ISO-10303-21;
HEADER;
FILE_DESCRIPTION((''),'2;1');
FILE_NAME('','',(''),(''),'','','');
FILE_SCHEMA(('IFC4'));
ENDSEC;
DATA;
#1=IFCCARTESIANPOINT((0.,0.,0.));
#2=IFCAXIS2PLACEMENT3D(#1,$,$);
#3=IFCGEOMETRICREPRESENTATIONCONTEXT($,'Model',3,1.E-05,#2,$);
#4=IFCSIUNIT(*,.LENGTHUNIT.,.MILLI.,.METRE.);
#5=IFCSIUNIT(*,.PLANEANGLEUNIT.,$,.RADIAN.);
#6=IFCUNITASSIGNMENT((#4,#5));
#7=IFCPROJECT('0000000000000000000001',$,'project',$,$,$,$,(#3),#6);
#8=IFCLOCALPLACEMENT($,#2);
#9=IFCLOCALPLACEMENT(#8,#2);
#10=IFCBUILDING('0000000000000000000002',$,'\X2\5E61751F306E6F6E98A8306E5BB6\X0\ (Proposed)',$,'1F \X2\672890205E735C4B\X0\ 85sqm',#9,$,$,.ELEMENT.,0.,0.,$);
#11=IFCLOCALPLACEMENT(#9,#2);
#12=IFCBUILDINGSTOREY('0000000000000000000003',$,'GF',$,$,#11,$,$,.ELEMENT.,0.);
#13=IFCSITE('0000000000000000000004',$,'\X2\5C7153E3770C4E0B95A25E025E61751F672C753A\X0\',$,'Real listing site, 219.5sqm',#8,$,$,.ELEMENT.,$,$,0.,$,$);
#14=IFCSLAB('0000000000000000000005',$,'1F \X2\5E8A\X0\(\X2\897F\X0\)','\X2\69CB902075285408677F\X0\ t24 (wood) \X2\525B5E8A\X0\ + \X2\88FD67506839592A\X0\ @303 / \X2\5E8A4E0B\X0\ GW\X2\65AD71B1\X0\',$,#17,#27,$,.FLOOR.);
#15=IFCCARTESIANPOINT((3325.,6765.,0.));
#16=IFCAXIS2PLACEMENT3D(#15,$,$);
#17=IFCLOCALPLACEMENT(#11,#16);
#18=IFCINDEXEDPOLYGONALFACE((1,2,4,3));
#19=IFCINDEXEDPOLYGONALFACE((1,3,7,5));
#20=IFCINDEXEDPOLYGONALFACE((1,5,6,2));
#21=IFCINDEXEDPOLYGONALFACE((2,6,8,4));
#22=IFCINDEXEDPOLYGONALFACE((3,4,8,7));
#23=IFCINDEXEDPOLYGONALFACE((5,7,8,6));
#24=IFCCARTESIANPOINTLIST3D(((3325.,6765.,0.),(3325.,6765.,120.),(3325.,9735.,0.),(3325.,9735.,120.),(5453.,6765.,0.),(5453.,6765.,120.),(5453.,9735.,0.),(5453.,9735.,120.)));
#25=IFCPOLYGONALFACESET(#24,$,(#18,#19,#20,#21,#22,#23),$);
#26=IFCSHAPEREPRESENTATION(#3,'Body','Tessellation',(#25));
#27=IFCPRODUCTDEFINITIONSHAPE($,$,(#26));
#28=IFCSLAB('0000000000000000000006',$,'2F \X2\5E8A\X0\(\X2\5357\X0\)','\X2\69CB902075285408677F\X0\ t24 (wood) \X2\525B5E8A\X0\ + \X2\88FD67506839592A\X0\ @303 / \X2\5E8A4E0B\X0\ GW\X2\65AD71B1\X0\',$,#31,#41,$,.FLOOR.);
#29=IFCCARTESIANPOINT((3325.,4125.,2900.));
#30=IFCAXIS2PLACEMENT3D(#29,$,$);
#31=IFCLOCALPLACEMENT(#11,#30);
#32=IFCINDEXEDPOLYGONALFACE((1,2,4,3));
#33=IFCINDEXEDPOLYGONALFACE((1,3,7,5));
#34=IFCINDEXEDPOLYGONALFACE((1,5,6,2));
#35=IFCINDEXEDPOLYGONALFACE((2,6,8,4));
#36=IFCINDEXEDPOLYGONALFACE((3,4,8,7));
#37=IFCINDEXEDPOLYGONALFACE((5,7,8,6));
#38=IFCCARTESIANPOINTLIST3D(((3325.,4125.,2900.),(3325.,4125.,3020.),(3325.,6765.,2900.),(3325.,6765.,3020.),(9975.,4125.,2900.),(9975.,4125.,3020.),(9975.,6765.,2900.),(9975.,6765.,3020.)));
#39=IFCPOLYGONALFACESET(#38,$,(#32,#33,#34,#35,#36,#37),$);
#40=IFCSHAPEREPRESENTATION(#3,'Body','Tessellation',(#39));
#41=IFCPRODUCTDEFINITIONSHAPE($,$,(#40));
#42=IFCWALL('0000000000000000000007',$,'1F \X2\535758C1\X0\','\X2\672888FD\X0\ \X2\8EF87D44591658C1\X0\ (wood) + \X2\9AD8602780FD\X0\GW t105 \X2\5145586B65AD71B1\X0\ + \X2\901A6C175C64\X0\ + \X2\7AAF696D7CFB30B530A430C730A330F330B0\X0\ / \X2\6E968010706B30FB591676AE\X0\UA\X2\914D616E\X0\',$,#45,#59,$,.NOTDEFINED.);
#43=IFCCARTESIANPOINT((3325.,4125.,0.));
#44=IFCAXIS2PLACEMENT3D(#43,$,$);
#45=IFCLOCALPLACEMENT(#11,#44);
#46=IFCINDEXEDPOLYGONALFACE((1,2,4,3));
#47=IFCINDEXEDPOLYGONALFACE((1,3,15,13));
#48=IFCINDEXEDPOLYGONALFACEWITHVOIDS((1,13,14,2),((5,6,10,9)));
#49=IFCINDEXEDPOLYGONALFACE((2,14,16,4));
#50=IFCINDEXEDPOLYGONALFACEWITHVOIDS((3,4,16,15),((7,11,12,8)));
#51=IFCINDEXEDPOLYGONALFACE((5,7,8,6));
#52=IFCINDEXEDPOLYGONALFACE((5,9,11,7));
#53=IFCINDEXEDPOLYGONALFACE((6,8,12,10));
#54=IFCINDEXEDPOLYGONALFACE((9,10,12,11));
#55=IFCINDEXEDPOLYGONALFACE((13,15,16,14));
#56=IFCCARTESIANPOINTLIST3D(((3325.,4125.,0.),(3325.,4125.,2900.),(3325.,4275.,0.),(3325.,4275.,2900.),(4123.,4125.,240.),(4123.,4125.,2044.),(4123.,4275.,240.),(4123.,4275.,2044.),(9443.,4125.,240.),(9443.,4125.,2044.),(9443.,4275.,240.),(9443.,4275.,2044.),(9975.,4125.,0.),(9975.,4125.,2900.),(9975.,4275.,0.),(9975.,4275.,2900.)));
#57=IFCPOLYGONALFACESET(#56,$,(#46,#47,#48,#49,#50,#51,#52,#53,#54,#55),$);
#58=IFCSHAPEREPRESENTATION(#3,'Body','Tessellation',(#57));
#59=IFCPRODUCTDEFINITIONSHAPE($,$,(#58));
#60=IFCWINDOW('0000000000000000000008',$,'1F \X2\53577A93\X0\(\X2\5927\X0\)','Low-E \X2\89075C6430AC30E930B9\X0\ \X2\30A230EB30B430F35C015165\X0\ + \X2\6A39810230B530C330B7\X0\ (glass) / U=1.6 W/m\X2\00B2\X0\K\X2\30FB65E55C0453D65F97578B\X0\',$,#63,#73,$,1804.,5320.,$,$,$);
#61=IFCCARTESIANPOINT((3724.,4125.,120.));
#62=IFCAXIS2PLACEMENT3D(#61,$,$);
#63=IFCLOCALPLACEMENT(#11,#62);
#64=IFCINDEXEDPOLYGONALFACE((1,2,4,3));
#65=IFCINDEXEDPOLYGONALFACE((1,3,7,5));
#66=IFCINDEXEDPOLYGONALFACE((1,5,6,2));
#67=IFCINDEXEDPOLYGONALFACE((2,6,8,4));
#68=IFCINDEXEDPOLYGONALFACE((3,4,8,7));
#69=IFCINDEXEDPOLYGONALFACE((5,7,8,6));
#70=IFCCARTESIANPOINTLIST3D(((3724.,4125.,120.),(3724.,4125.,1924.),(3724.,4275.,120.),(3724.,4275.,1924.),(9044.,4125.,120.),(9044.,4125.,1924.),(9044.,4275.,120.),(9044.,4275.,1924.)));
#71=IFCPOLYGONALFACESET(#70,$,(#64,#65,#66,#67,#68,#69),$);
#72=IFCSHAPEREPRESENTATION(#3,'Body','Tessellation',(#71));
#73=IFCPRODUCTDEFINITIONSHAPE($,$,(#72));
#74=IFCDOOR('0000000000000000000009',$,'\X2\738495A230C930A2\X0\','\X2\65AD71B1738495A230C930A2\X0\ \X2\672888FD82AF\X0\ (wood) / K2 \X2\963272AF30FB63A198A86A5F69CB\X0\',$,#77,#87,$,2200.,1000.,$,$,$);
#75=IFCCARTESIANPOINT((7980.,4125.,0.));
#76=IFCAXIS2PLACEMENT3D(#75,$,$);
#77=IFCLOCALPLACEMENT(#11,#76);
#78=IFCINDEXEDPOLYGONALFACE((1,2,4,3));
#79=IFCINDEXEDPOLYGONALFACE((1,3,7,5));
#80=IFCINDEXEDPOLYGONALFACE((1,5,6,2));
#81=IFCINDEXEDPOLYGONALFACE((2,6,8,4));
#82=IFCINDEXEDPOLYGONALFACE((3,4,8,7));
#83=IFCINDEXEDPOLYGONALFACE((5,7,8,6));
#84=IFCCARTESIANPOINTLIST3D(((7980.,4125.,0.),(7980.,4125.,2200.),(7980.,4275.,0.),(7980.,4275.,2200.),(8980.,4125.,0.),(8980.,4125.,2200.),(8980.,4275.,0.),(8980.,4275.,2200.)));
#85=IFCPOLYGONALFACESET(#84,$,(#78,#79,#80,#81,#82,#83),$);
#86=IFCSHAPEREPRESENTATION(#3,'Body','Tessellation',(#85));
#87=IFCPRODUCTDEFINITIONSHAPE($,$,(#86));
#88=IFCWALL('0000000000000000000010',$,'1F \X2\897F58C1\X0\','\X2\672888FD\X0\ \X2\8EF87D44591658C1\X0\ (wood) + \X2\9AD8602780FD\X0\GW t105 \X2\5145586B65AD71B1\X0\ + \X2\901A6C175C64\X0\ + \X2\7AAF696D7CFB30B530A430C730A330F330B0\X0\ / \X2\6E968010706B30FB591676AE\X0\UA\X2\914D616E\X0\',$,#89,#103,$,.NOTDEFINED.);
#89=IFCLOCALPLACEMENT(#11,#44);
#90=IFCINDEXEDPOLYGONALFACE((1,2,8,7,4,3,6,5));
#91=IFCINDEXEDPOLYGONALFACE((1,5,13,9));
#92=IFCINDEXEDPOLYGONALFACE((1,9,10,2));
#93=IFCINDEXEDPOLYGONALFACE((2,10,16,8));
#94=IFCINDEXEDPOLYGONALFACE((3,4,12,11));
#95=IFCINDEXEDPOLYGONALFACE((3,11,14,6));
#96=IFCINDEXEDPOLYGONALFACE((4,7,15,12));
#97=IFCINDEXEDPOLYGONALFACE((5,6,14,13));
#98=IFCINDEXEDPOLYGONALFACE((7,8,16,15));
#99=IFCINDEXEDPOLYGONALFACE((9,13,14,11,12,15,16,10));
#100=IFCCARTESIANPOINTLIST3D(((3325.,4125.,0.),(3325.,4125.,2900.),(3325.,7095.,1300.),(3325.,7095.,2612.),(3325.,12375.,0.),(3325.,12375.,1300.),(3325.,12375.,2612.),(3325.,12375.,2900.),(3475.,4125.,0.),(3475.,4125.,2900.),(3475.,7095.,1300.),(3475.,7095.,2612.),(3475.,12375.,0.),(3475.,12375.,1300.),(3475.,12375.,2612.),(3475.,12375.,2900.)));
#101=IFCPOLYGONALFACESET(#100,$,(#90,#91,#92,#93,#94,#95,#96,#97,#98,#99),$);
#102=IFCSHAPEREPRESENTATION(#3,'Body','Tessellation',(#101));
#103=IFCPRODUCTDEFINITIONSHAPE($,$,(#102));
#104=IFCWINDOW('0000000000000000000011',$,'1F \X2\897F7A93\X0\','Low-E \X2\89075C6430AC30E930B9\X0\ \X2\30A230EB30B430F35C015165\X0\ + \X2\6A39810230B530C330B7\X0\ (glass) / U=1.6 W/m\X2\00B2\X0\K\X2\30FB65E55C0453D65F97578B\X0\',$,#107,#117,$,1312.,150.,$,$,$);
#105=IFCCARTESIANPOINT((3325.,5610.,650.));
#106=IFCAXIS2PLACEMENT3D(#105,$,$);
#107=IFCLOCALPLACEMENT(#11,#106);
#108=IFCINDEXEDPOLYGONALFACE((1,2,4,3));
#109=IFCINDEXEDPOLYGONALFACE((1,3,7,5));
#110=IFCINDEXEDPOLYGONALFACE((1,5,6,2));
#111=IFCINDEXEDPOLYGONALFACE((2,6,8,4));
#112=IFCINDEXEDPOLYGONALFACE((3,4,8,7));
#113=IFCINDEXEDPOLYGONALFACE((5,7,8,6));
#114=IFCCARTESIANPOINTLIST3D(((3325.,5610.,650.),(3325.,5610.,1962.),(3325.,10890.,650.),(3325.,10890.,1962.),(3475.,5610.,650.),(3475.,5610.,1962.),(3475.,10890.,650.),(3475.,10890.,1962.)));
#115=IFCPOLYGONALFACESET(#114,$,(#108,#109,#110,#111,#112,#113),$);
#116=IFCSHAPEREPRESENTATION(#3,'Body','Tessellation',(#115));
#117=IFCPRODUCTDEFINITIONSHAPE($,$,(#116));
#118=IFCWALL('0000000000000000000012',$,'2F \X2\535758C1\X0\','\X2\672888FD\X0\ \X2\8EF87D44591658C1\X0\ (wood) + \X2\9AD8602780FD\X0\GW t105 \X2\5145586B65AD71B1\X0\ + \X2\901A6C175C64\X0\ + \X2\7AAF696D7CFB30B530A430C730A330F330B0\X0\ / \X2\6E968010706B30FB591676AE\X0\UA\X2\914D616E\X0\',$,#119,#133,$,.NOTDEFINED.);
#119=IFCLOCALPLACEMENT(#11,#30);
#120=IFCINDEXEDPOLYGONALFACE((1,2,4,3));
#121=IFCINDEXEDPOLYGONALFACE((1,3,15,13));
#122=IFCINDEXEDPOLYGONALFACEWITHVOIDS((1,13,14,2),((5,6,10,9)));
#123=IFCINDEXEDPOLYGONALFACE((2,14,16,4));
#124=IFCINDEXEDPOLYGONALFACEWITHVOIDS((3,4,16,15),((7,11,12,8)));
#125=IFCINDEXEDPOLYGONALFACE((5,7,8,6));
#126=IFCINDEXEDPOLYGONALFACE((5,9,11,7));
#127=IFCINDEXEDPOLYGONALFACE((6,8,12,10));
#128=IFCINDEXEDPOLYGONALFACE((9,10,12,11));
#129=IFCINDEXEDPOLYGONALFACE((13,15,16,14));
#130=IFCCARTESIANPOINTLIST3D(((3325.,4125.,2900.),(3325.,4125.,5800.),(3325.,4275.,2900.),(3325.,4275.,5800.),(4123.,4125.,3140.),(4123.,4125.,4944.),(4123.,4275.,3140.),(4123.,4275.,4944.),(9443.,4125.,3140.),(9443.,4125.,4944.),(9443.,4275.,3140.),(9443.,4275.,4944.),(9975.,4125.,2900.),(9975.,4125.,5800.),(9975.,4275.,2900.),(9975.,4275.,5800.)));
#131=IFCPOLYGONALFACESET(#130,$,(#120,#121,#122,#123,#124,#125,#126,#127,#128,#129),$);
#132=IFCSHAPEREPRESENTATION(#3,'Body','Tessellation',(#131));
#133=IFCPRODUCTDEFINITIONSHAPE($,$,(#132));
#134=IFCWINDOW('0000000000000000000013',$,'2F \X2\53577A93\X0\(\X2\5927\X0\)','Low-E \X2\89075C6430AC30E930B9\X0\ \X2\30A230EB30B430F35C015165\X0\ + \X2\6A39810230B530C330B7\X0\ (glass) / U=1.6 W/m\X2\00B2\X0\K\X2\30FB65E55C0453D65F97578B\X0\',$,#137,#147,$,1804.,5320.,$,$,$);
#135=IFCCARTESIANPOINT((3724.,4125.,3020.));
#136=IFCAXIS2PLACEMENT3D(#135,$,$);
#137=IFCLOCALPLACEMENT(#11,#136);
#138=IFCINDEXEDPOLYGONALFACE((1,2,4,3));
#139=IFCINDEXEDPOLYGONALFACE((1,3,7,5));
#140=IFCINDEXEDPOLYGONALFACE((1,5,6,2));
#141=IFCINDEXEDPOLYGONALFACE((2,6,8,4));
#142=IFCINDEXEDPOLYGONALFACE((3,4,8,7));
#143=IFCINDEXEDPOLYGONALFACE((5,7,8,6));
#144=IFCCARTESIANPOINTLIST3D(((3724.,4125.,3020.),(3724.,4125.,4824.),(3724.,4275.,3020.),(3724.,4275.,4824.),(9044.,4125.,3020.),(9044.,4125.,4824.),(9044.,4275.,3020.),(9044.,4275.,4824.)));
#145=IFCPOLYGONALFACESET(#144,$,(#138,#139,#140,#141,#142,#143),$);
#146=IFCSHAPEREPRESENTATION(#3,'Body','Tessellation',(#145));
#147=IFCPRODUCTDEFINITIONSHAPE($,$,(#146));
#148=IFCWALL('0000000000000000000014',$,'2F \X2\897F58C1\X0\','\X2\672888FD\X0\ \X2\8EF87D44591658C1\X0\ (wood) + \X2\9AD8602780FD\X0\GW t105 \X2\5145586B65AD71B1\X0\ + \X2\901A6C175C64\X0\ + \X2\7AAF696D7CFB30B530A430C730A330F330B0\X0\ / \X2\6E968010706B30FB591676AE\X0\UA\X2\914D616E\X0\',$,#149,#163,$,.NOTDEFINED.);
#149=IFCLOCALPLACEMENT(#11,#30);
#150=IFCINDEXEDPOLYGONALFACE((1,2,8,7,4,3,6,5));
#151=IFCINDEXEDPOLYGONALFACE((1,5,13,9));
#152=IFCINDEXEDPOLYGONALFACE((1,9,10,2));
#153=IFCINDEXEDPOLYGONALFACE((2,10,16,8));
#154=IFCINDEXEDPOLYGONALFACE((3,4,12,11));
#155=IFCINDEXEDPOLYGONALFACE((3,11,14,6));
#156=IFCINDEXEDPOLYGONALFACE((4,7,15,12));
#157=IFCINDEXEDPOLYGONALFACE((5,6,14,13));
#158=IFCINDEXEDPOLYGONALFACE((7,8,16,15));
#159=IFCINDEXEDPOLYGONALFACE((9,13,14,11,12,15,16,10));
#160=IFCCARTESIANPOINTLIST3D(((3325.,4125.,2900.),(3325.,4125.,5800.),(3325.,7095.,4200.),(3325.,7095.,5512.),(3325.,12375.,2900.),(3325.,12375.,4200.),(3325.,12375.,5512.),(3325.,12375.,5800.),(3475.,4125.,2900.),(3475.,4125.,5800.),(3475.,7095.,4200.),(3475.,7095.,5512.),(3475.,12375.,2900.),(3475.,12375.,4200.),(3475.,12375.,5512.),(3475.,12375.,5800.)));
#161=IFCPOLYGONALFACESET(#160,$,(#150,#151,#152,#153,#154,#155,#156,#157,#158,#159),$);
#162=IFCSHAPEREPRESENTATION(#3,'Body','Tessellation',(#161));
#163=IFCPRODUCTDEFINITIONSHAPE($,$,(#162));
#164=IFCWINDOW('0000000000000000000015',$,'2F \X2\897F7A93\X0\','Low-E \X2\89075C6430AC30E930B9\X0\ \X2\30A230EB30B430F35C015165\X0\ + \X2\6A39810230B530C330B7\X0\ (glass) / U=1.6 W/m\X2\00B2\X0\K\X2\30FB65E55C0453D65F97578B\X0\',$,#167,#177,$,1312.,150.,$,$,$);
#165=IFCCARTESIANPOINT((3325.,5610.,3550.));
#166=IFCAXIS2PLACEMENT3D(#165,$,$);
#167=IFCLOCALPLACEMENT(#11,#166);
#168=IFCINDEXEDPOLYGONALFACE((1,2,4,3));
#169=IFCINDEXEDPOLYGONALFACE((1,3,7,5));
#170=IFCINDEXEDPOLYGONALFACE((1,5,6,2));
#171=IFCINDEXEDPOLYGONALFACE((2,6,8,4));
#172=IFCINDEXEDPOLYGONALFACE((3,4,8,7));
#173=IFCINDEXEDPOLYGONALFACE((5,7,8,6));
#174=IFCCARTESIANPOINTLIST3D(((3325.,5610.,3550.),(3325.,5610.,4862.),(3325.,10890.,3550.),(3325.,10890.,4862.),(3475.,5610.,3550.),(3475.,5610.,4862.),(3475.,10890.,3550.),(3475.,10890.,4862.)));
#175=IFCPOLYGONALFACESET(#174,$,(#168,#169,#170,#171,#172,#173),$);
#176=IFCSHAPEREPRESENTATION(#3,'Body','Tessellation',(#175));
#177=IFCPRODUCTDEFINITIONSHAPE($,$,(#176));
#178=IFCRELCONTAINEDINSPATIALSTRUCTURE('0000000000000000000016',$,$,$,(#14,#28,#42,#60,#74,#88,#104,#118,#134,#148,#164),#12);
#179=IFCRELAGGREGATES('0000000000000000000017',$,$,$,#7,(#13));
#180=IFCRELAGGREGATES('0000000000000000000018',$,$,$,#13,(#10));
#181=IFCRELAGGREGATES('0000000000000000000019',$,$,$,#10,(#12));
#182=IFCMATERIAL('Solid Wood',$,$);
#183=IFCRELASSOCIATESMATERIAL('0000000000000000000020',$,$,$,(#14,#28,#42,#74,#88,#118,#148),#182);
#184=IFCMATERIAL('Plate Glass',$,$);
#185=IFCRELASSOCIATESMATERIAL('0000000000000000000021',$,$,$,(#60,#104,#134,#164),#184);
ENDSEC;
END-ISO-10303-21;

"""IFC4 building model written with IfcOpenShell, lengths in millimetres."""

from ifc_helpers import new_model, si_unit, frame, frame_2d, origin, place, context, project, spatial, rectangle, extrude, material, element, fill, save


model = new_model("IFC4")

# Units and contexts
model_context = context("Model", 3, precision=1e-05, world=origin())
ifc_project = project(units=[si_unit("LENGTHUNIT", "METRE", prefix="MILLI"), si_unit("PLANEANGLEUNIT", "RADIAN")], contexts=[model_context])

# Site, building, storey
site_placement = place(None, origin())
site = spatial("IfcSite", under=ifc_project, at=site_placement, Name="山口県下関市幡生本町", ObjectType="Real listing site, 219.5sqm", CompositionType="ELEMENT", RefElevation=0.0)
building_placement = place(site_placement, origin())
building = spatial("IfcBuilding", under=site, at=building_placement, Name="幡生の潮風の家 (Proposed)", ObjectType="1F 木造平屋 85sqm", CompositionType="ELEMENT", ElevationOfRefHeight=0.0, ElevationOfTerrain=0.0)
storey_placement = place(building_placement, origin())
storey = spatial("IfcBuildingStorey", under=building, at=storey_placement, Name="GF", CompositionType="ELEMENT", Elevation=0.0)

# Slabs
ifc_material_1 = material(Name="Solid Wood")
slab_1_placement = place(storey_placement, frame((3325.0, 6765.0, 0.0)))
element("IfcSlab", 1, at=slab_1_placement, inside=storey, material=ifc_material_1, Name="1F 床(西)", Description="構造用合板 t24 (wood) 剛床 + 製材根太 @303 / 床下 GW断熱", PredefinedType="FLOOR", context=model_context, shape_type="SweptSolid", body=[
    extrude(rectangle(XDim=2128.0, YDim=2970.0, at=frame_2d((1064.0, 1485.0))), frame((3325.0, 6765.0, 0.0)), (0.0, 0.0, 1.0), 120.0),
])
slab_2_placement = place(storey_placement, frame((3325.0, 4125.0, 2900.0)))
element("IfcSlab", 2, at=slab_2_placement, inside=storey, material=ifc_material_1, Name="2F 床(南)", Description="構造用合板 t24 (wood) 剛床 + 製材根太 @303 / 床下 GW断熱", PredefinedType="FLOOR", context=model_context, shape_type="SweptSolid", body=[
    extrude(rectangle(XDim=6650.0, YDim=2640.0, at=frame_2d((3325.0, 1320.0))), frame((3325.0, 4125.0, 2900.0)), (0.0, 0.0, 1.0), 120.0),
])

# Wall, openings, window, door
wall_1_placement = place(storey_placement, frame((3325.0, 4125.0, 0.0)))
wall_1 = element("IfcWall", 3, at=wall_1_placement, inside=storey, material=ifc_material_1, Name="1F 南壁", Description="木製 軸組外壁 (wood) + 高性能GW t105 充填断熱 + 通気層 + 窯業系サイディング / 準耐火・外皮UA配慮", PredefinedType="NOTDEFINED", context=model_context, shape_type="SweptSolid", body=[
    extrude(rectangle(XDim=6650.0, YDim=150.0, at=frame_2d((3325.0, 75.0))), frame((3325.0, 4125.0, 0.0)), (0.0, 0.0, 1.0), 2900.0),
])
opening_1_placement = place(storey_placement, frame((3724.0, 4125.0, 120.0)))
opening_1 = element("IfcOpeningElement", 4, at=opening_1_placement, cuts=wall_1, PredefinedType="NOTDEFINED", context=model_context, shape_type="SweptSolid", body=[
    extrude(rectangle(XDim=5320.0, YDim=150.0, at=frame_2d((2660.0, 75.0))), frame((3724.0, 4125.0, 120.0)), (0.0, 0.0, 1.0), 1804.0),
])
opening_2_placement = place(storey_placement, frame((7980.0, 4125.0, 0.0)))
opening_2 = element("IfcOpeningElement", 5, at=opening_2_placement, cuts=wall_1, PredefinedType="NOTDEFINED", context=model_context, shape_type="SweptSolid", body=[
    extrude(rectangle(XDim=1000.0, YDim=150.0, at=frame_2d((500.0, 75.0))), frame((7980.0, 4125.0, 0.0)), (0.0, 0.0, 1.0), 2200.0),
])
ifc_material_2 = material(Name="Plate Glass")
window_1_placement = place(storey_placement, frame((3724.0, 4125.0, 120.0)))
window_1 = element("IfcWindow", 6, at=window_1_placement, inside=storey, material=ifc_material_2, Name="1F 南窓(大)", Description="Low-E 複層ガラス アルゴン封入 + 樹脂サッシ (glass) / U=1.6 W/m²K・日射取得型", OverallHeight=1804.0, OverallWidth=5320.0, context=model_context, shape_type="SweptSolid", body=[
    extrude(rectangle(XDim=5320.0, YDim=150.0, at=frame_2d((2660.0, 75.0))), frame((3724.0, 4125.0, 120.0)), (0.0, 0.0, 1.0), 1804.0),
])
fill(opening_1, window_1)
door_placement = place(storey_placement, frame((7980.0, 4125.0, 0.0)))
door = element("IfcDoor", 7, at=door_placement, inside=storey, material=ifc_material_1, Name="玄関ドア", Description="断熱玄関ドア 木製芯 (wood) / K2 防犯・採風機構", OverallHeight=2200.0, OverallWidth=1000.0, context=model_context, shape_type="SweptSolid", body=[
    extrude(rectangle(XDim=1000.0, YDim=150.0, at=frame_2d((500.0, 75.0))), frame((7980.0, 4125.0, 0.0)), (0.0, 0.0, 1.0), 2200.0),
])
fill(opening_2, door)

# Walls, openings, windows
wall_2_placement = place(storey_placement, frame((3325.0, 4125.0, 0.0)))
wall_2 = element("IfcWall", 8, at=wall_2_placement, inside=storey, material=ifc_material_1, Name="1F 西壁", Description="木製 軸組外壁 (wood) + 高性能GW t105 充填断熱 + 通気層 + 窯業系サイディング / 準耐火・外皮UA配慮", PredefinedType="NOTDEFINED", context=model_context, shape_type="SweptSolid", body=[
    extrude(rectangle(XDim=150.0, YDim=8250.0, at=frame_2d((75.0, 4125.0))), frame((3325.0, 4125.0, 0.0)), (0.0, 0.0, 1.0), 2900.0),
])
opening_3_placement = place(storey_placement, frame((3325.0, 5610.0, 650.0)))
opening_3 = element("IfcOpeningElement", 9, at=opening_3_placement, cuts=wall_2, PredefinedType="NOTDEFINED", context=model_context, shape_type="SweptSolid", body=[
    extrude(rectangle(XDim=150.0, YDim=5280.0, at=frame_2d((75.0, 2640.0))), frame((3325.0, 5610.0, 650.0)), (0.0, 0.0, 1.0), 1312.0),
])
window_2_placement = place(storey_placement, frame((3325.0, 5610.0, 650.0)))
window_2 = element("IfcWindow", 10, at=window_2_placement, inside=storey, material=ifc_material_2, Name="1F 西窓", Description="Low-E 複層ガラス アルゴン封入 + 樹脂サッシ (glass) / U=1.6 W/m²K・日射取得型", OverallHeight=1312.0, OverallWidth=150.0, context=model_context, shape_type="SweptSolid", body=[
    extrude(rectangle(XDim=150.0, YDim=5280.0, at=frame_2d((75.0, 2640.0))), frame((3325.0, 5610.0, 650.0)), (0.0, 0.0, 1.0), 1312.0),
])
fill(opening_3, window_2)
wall_3_placement = place(storey_placement, frame((3325.0, 4125.0, 2900.0)))
wall_3 = element("IfcWall", 11, at=wall_3_placement, inside=storey, material=ifc_material_1, Name="2F 南壁", Description="木製 軸組外壁 (wood) + 高性能GW t105 充填断熱 + 通気層 + 窯業系サイディング / 準耐火・外皮UA配慮", PredefinedType="NOTDEFINED", context=model_context, shape_type="SweptSolid", body=[
    extrude(rectangle(XDim=6650.0, YDim=150.0, at=frame_2d((3325.0, 75.0))), frame((3325.0, 4125.0, 2900.0)), (0.0, 0.0, 1.0), 2900.0),
])
opening_4_placement = place(storey_placement, frame((3724.0, 4125.0, 3020.0)))
opening_4 = element("IfcOpeningElement", 12, at=opening_4_placement, cuts=wall_3, PredefinedType="NOTDEFINED", context=model_context, shape_type="SweptSolid", body=[
    extrude(rectangle(XDim=5320.0, YDim=150.0, at=frame_2d((2660.0, 75.0))), frame((3724.0, 4125.0, 3020.0)), (0.0, 0.0, 1.0), 1804.0),
])
window_3_placement = place(storey_placement, frame((3724.0, 4125.0, 3020.0)))
window_3 = element("IfcWindow", 13, at=window_3_placement, inside=storey, material=ifc_material_2, Name="2F 南窓(大)", Description="Low-E 複層ガラス アルゴン封入 + 樹脂サッシ (glass) / U=1.6 W/m²K・日射取得型", OverallHeight=1804.0, OverallWidth=5320.0, context=model_context, shape_type="SweptSolid", body=[
    extrude(rectangle(XDim=5320.0, YDim=150.0, at=frame_2d((2660.0, 75.0))), frame((3724.0, 4125.0, 3020.0)), (0.0, 0.0, 1.0), 1804.0),
])
fill(opening_4, window_3)
wall_4_placement = place(storey_placement, frame((3325.0, 4125.0, 2900.0)))
wall_4 = element("IfcWall", 14, at=wall_4_placement, inside=storey, material=ifc_material_1, Name="2F 西壁", Description="木製 軸組外壁 (wood) + 高性能GW t105 充填断熱 + 通気層 + 窯業系サイディング / 準耐火・外皮UA配慮", PredefinedType="NOTDEFINED", context=model_context, shape_type="SweptSolid", body=[
    extrude(rectangle(XDim=150.0, YDim=8250.0, at=frame_2d((75.0, 4125.0))), frame((3325.0, 4125.0, 2900.0)), (0.0, 0.0, 1.0), 2900.0),
])
opening_5_placement = place(storey_placement, frame((3325.0, 5610.0, 3550.0)))
opening_5 = element("IfcOpeningElement", 15, at=opening_5_placement, cuts=wall_4, PredefinedType="NOTDEFINED", context=model_context, shape_type="SweptSolid", body=[
    extrude(rectangle(XDim=150.0, YDim=5280.0, at=frame_2d((75.0, 2640.0))), frame((3325.0, 5610.0, 3550.0)), (0.0, 0.0, 1.0), 1312.0),
])
window_4_placement = place(storey_placement, frame((3325.0, 5610.0, 3550.0)))
window_4 = element("IfcWindow", 16, at=window_4_placement, inside=storey, material=ifc_material_2, Name="2F 西窓", Description="Low-E 複層ガラス アルゴン封入 + 樹脂サッシ (glass) / U=1.6 W/m²K・日射取得型", OverallHeight=1312.0, OverallWidth=150.0, context=model_context, shape_type="SweptSolid", body=[
    extrude(rectangle(XDim=150.0, YDim=5280.0, at=frame_2d((75.0, 2640.0))), frame((3325.0, 5610.0, 3550.0)), (0.0, 0.0, 1.0), 1312.0),
])
fill(opening_5, window_4)

save(model, "model.ifc")
